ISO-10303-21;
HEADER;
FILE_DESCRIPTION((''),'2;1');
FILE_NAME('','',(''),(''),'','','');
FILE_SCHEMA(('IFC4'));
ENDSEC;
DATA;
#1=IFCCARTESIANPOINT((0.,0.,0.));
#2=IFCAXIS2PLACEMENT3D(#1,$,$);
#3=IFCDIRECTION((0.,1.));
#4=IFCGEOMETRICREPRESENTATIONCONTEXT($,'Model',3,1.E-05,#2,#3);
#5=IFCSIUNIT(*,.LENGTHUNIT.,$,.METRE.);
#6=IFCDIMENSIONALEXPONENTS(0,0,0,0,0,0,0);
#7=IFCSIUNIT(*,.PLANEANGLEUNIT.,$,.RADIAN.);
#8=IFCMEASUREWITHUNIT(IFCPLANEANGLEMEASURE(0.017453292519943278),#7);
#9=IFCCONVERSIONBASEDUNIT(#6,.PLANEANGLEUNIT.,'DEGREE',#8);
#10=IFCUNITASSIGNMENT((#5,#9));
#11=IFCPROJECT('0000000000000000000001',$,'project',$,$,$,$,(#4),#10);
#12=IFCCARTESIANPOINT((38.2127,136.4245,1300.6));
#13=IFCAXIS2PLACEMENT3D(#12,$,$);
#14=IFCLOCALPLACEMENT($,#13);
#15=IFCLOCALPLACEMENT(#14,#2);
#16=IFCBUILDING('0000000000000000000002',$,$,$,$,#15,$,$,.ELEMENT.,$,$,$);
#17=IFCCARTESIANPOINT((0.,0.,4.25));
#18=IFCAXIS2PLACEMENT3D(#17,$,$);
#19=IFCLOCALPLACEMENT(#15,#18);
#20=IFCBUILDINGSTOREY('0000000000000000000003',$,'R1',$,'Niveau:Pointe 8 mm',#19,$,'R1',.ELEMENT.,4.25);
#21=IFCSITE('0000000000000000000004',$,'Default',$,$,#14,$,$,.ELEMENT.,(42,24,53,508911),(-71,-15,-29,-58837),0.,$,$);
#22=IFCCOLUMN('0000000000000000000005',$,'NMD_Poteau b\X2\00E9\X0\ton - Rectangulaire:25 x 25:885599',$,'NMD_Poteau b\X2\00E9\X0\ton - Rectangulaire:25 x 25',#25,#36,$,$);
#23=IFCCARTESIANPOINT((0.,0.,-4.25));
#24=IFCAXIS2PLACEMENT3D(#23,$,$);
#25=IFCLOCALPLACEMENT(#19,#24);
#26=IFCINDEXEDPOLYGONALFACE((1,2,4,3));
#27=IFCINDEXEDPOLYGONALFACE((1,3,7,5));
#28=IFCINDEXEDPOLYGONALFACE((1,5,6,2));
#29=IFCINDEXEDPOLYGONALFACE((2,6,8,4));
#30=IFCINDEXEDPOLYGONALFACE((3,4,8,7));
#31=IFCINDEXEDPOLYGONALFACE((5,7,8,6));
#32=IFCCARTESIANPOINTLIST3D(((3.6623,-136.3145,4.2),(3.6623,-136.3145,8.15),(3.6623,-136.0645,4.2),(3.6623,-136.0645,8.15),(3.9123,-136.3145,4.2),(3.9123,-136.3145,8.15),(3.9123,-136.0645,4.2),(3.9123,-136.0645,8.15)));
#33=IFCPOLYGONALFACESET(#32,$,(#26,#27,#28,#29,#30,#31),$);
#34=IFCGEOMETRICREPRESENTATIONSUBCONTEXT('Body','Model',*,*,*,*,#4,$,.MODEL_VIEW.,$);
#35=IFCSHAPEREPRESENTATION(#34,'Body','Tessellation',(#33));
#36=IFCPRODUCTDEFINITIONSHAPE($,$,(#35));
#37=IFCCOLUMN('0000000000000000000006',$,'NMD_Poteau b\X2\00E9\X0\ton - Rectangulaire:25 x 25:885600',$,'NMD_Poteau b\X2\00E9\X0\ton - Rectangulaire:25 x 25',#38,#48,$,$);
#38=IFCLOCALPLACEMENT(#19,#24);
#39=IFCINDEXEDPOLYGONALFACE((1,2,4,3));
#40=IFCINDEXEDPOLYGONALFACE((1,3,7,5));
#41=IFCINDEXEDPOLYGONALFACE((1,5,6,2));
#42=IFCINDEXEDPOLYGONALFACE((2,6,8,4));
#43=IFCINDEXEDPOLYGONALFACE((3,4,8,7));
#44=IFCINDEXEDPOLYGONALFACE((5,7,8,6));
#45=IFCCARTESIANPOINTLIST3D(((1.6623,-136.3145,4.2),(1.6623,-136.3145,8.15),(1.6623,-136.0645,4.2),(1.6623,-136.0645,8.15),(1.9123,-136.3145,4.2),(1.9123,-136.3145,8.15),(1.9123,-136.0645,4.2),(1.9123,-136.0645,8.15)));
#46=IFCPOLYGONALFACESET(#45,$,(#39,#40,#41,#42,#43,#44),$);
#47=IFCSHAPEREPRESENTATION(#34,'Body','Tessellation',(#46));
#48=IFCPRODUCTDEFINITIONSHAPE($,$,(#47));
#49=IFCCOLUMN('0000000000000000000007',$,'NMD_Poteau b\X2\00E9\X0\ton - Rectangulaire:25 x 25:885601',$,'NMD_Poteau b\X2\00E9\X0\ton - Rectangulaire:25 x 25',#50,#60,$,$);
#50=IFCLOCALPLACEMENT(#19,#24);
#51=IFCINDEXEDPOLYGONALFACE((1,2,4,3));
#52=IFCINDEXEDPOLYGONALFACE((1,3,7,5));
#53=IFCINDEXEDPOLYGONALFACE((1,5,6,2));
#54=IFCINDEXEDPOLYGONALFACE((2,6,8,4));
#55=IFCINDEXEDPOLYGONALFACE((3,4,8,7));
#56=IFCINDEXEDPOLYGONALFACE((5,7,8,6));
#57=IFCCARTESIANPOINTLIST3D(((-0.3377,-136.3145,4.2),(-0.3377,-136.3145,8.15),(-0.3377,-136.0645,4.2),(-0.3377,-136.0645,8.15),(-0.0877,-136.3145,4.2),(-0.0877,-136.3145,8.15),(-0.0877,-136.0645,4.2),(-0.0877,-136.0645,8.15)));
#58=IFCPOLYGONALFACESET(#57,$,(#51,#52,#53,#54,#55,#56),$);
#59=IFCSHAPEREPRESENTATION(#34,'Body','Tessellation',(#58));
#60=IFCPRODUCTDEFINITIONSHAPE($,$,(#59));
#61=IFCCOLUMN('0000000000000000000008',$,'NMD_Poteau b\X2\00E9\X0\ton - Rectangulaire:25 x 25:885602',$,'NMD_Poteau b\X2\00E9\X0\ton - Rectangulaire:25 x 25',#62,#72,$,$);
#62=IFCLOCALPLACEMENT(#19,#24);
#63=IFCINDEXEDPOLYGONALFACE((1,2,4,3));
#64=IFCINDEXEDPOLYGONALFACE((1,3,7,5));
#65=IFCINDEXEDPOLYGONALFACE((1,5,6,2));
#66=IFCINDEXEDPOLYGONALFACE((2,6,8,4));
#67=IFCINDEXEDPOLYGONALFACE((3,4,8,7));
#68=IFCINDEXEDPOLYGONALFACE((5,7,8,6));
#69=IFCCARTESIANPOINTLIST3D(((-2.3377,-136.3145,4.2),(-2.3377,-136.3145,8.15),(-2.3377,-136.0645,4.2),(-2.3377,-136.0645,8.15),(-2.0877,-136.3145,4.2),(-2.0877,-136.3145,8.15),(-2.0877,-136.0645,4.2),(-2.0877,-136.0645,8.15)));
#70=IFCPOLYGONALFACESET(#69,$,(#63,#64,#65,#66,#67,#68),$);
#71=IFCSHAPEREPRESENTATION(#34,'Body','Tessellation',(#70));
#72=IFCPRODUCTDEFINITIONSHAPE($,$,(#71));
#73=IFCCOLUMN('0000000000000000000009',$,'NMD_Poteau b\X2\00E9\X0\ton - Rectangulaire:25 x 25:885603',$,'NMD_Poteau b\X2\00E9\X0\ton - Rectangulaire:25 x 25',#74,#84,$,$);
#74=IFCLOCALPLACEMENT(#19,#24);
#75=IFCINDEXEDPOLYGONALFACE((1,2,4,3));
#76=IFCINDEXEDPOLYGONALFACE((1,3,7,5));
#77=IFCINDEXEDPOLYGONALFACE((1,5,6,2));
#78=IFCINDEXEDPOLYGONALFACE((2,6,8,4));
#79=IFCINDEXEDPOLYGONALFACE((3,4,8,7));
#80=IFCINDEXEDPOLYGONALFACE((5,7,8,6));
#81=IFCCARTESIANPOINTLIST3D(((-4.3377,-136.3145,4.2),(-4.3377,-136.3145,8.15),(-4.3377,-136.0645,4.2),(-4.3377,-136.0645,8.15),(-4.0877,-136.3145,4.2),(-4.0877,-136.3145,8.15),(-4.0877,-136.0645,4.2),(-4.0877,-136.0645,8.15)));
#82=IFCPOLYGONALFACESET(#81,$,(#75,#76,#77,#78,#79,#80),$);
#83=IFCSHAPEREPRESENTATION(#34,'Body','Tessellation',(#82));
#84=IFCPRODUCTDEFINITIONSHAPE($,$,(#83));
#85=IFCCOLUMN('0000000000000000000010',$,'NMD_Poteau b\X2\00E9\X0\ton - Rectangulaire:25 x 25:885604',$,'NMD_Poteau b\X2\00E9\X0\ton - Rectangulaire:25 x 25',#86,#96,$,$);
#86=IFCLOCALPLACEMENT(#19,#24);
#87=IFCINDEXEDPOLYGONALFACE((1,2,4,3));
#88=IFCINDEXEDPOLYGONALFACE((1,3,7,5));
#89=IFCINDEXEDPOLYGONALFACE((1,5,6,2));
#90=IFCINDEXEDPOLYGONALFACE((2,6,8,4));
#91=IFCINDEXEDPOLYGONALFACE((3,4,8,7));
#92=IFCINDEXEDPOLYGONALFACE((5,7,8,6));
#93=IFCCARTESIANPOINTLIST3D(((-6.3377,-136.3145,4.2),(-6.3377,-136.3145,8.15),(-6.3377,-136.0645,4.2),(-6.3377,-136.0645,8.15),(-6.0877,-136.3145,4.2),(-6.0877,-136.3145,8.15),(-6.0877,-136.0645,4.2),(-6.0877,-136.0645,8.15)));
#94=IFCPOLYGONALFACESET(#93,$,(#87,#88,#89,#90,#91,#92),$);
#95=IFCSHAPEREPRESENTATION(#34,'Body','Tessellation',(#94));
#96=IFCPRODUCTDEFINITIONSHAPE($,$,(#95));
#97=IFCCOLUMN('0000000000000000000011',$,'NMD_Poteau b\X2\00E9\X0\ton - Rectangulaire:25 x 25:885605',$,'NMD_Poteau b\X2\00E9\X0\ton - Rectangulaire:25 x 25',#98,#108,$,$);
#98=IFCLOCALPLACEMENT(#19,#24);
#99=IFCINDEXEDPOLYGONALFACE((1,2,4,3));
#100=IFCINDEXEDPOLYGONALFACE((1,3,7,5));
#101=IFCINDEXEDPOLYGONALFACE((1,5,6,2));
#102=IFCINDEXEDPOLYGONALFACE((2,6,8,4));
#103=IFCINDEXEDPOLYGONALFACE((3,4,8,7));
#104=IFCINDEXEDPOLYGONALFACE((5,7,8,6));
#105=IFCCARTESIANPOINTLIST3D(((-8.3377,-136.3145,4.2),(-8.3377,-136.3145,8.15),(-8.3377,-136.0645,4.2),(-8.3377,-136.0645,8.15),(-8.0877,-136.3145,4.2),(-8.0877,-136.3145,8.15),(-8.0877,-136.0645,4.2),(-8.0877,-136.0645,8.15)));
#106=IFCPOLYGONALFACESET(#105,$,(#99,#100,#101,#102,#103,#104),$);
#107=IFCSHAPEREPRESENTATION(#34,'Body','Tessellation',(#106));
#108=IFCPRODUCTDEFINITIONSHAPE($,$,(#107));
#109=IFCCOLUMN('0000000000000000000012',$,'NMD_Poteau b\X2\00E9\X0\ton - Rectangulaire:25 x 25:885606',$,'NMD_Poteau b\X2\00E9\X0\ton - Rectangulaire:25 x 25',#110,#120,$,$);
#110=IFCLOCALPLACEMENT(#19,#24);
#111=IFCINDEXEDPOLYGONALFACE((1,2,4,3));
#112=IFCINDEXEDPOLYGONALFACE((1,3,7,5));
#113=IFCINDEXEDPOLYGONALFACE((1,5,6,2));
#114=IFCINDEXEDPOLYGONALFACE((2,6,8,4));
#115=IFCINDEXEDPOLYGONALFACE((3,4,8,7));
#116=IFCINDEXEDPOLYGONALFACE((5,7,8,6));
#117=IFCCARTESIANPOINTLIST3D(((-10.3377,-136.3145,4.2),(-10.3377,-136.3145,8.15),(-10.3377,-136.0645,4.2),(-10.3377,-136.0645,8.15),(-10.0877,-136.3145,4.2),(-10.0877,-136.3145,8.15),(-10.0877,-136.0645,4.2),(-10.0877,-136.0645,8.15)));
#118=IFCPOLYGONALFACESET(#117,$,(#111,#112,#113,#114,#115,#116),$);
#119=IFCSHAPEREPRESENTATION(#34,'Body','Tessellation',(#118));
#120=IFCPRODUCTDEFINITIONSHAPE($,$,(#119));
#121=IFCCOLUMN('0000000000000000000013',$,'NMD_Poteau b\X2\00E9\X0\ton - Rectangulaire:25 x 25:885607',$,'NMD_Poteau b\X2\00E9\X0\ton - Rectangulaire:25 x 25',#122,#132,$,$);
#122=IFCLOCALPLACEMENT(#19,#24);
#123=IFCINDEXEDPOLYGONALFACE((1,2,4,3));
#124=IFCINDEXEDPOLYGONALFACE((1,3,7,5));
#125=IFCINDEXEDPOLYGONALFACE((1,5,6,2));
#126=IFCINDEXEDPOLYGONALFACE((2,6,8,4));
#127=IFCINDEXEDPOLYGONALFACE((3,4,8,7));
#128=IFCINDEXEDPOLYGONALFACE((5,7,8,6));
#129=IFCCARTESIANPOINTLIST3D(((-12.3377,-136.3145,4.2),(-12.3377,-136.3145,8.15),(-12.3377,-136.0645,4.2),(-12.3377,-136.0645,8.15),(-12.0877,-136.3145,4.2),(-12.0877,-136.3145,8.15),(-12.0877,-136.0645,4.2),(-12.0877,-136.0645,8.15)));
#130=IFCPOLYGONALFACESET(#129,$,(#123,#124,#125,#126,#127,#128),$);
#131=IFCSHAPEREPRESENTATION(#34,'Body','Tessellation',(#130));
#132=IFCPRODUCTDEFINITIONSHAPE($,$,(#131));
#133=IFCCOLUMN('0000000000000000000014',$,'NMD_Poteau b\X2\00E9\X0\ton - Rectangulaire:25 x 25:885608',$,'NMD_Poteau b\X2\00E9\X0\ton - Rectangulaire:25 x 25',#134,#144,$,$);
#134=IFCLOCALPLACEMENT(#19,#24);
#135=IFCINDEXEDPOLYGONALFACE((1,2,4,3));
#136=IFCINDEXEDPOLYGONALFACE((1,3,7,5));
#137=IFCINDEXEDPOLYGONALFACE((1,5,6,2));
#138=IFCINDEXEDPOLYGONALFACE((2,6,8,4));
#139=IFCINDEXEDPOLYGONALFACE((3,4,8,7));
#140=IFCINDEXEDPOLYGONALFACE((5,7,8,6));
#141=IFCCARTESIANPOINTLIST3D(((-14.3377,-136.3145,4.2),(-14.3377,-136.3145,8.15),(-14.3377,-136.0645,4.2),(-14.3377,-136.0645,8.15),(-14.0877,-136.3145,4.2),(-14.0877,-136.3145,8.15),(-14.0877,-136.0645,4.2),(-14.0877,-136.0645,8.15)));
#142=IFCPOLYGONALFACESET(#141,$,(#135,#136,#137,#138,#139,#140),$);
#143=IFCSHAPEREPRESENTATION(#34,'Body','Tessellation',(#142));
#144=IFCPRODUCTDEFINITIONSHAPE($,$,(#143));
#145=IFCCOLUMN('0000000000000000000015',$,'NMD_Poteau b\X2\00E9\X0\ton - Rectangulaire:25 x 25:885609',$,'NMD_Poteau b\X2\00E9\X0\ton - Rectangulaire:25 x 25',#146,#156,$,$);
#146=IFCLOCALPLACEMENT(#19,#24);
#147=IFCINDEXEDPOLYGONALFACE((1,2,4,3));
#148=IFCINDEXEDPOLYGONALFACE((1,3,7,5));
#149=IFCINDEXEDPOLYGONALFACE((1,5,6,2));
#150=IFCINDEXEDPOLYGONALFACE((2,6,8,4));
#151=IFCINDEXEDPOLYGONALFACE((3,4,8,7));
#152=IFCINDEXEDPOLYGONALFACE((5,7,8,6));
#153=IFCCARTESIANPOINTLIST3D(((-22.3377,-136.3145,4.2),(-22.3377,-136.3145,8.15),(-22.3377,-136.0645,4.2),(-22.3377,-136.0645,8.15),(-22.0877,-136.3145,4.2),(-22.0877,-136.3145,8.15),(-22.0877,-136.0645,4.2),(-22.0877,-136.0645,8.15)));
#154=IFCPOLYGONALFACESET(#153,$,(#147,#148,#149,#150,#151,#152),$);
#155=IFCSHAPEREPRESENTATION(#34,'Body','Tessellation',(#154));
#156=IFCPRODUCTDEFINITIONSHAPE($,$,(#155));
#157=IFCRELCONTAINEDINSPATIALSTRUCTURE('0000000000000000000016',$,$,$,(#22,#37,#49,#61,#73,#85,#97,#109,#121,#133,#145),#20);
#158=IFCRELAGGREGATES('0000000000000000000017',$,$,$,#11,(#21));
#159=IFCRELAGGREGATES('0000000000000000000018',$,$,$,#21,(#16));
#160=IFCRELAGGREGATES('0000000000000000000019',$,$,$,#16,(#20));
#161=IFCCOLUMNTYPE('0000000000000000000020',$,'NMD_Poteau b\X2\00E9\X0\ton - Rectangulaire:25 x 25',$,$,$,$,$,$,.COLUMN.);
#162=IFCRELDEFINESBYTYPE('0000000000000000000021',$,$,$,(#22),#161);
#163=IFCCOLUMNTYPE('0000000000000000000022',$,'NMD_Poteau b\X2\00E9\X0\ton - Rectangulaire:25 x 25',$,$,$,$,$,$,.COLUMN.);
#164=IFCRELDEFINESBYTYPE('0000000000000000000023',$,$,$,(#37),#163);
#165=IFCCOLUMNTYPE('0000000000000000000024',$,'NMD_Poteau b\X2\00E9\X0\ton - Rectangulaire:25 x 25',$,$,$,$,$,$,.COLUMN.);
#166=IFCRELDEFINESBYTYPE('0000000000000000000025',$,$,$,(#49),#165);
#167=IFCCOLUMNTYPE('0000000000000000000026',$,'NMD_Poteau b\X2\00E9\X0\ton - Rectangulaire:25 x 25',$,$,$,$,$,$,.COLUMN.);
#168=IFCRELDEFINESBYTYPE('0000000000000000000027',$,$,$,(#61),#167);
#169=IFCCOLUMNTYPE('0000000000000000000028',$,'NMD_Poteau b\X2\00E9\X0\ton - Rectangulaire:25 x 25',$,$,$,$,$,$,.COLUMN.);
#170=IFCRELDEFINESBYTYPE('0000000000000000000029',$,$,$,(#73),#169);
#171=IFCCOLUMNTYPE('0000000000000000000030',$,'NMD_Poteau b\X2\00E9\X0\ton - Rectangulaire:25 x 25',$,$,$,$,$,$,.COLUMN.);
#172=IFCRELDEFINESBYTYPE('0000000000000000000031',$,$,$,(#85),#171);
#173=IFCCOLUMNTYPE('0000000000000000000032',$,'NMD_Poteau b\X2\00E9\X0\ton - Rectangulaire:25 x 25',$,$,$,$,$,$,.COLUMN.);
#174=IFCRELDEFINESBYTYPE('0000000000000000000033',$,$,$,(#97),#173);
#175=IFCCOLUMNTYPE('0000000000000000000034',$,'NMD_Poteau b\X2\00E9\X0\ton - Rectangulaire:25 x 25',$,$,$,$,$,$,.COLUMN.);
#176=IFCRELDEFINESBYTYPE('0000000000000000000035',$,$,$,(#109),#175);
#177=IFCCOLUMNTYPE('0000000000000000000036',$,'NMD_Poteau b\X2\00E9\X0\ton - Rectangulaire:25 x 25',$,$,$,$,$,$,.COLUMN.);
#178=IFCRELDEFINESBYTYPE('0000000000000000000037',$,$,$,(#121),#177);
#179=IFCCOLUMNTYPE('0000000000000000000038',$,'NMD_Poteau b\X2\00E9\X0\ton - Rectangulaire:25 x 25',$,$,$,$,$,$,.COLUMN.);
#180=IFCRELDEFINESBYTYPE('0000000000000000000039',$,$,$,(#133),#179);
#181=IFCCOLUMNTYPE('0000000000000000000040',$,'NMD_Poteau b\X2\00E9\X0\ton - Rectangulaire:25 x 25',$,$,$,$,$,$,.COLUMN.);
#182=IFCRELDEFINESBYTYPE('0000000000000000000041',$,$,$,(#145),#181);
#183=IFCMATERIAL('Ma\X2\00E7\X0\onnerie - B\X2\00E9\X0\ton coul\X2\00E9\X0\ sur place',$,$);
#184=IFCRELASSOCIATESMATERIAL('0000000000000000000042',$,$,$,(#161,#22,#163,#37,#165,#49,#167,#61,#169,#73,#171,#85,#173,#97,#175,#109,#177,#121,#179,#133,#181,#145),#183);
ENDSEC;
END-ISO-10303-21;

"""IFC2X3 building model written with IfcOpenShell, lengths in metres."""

from ifc_helpers import new_model, entity, si_unit, converted_unit, direction, frame, frame_2d, origin, place, context, subcontext, project, spatial, rectangle, extrude, source, transform, mapped, material, type_object, type_shapes, element, save


model = new_model("IFC2X3")

# Units and contexts
model_context = context("Model", 3, precision=1e-05, world=origin(), true_north=direction((0.0, 1.0)))
body_context = subcontext(model_context, "Body", "Model", "MODEL_VIEW")
ifc_project = project(units=[si_unit("LENGTHUNIT", "METRE"), converted_unit("PLANEANGLEUNIT", "DEGREE", entity("IfcPlaneAngleMeasure", 0.017453292519943278), si_unit("PLANEANGLEUNIT", "RADIAN"), dimensions=[0, 0, 0, 0, 0, 0, 0])], contexts=[model_context])

# Site, building, storey
site_placement = place(None, frame((38.2127, 136.4245, 1300.6)))
site = spatial("IfcSite", under=ifc_project, at=site_placement, Name="Default", CompositionType="ELEMENT", RefLatitude=(42, 24, 53, 508911), RefLongitude=(-71, -15, -29, -58837), RefElevation=0.0)
building_placement = place(site_placement, origin())
building = spatial("IfcBuilding", under=site, at=building_placement, CompositionType="ELEMENT")
storey_placement = place(building_placement, frame((0.0, 0.0, 4.25)))
storey = spatial("IfcBuildingStorey", under=building, at=storey_placement, Name="R1", ObjectType="Niveau:Pointe 8 mm", LongName="R1", CompositionType="ELEMENT", Elevation=4.25)

# Columns
ifc_material = material(Name="Maçonnerie - Béton coulé sur place")
column_type_1 = type_object("IfcColumnType", Name="NMD_Poteau béton - Rectangulaire:25 x 25", PredefinedType="COLUMN", material=ifc_material)
shared_shape_1 = source(origin(), body_context, "Body", "SweptSolid", [
    extrude(rectangle(XDim=0.25, YDim=0.25, at=frame_2d((0.0, 0.0), x_axis=(1.0, 0.0))), frame((3.7873, -136.1895, 4.2), z_axis=(0.0, 0.0, 1.0), x_axis=(-1.0, 0.0, 0.0)), (0.0, 0.0, 1.0), 3.95),
])
type_shapes(column_type_1, [shared_shape_1])
column_1_placement = place(storey_placement, frame((0.0, 0.0, -4.25)))
element("IfcColumn", 1, at=column_1_placement, inside=storey, type_object=column_type_1, material=ifc_material, Name="NMD_Poteau béton - Rectangulaire:25 x 25:885599", ObjectType="NMD_Poteau béton - Rectangulaire:25 x 25", context=body_context, shape_type="MappedRepresentation", body=[
    mapped(shared_shape_1, transform((0.0, 0.0, 0.0), scale=1.0)),
])
column_type_2 = type_object("IfcColumnType", Name="NMD_Poteau béton - Rectangulaire:25 x 25", PredefinedType="COLUMN", material=ifc_material)
shared_shape_2 = source(origin(), body_context, "Body", "SweptSolid", [
    extrude(rectangle(XDim=0.25, YDim=0.25, at=frame_2d((0.0, 0.0), x_axis=(1.0, 0.0))), frame((1.7873, -136.1895, 4.2), z_axis=(0.0, 0.0, 1.0), x_axis=(-1.0, 0.0, 0.0)), (0.0, 0.0, 1.0), 3.95),
])
type_shapes(column_type_2, [shared_shape_2])
column_2_placement = place(storey_placement, frame((0.0, 0.0, -4.25)))
element("IfcColumn", 2, at=column_2_placement, inside=storey, type_object=column_type_2, material=ifc_material, Name="NMD_Poteau béton - Rectangulaire:25 x 25:885600", ObjectType="NMD_Poteau béton - Rectangulaire:25 x 25", context=body_context, shape_type="MappedRepresentation", body=[
    mapped(shared_shape_2, transform((0.0, 0.0, 0.0), scale=1.0)),
])
column_type_3 = type_object("IfcColumnType", Name="NMD_Poteau béton - Rectangulaire:25 x 25", PredefinedType="COLUMN", material=ifc_material)
shared_shape_3 = source(origin(), body_context, "Body", "SweptSolid", [
    extrude(rectangle(XDim=0.25, YDim=0.25, at=frame_2d((0.0, 0.0), x_axis=(1.0, 0.0))), frame((-0.2127, -136.1895, 4.2), z_axis=(0.0, 0.0, 1.0), x_axis=(-1.0, 0.0, 0.0)), (0.0, 0.0, 1.0), 3.95),
])
type_shapes(column_type_3, [shared_shape_3])
column_3_placement = place(storey_placement, frame((0.0, 0.0, -4.25)))
element("IfcColumn", 3, at=column_3_placement, inside=storey, type_object=column_type_3, material=ifc_material, Name="NMD_Poteau béton - Rectangulaire:25 x 25:885601", ObjectType="NMD_Poteau béton - Rectangulaire:25 x 25", context=body_context, shape_type="MappedRepresentation", body=[
    mapped(shared_shape_3, transform((0.0, 0.0, 0.0), scale=1.0)),
])
column_type_4 = type_object("IfcColumnType", Name="NMD_Poteau béton - Rectangulaire:25 x 25", PredefinedType="COLUMN", material=ifc_material)
shared_shape_4 = source(origin(), body_context, "Body", "SweptSolid", [
    extrude(rectangle(XDim=0.25, YDim=0.25, at=frame_2d((0.0, 0.0), x_axis=(1.0, 0.0))), frame((-2.2127, -136.1895, 4.2), z_axis=(0.0, 0.0, 1.0), x_axis=(-1.0, 0.0, 0.0)), (0.0, 0.0, 1.0), 3.95),
])
type_shapes(column_type_4, [shared_shape_4])
column_4_placement = place(storey_placement, frame((0.0, 0.0, -4.25)))
element("IfcColumn", 4, at=column_4_placement, inside=storey, type_object=column_type_4, material=ifc_material, Name="NMD_Poteau béton - Rectangulaire:25 x 25:885602", ObjectType="NMD_Poteau béton - Rectangulaire:25 x 25", context=body_context, shape_type="MappedRepresentation", body=[
    mapped(shared_shape_4, transform((0.0, 0.0, 0.0), scale=1.0)),
])
column_type_5 = type_object("IfcColumnType", Name="NMD_Poteau béton - Rectangulaire:25 x 25", PredefinedType="COLUMN", material=ifc_material)
shared_shape_5 = source(origin(), body_context, "Body", "SweptSolid", [
    extrude(rectangle(XDim=0.25, YDim=0.25, at=frame_2d((0.0, 0.0), x_axis=(1.0, 0.0))), frame((-4.2127, -136.1895, 4.2), z_axis=(0.0, 0.0, 1.0), x_axis=(-1.0, 0.0, 0.0)), (0.0, 0.0, 1.0), 3.95),
])
type_shapes(column_type_5, [shared_shape_5])
column_5_placement = place(storey_placement, frame((0.0, 0.0, -4.25)))
element("IfcColumn", 5, at=column_5_placement, inside=storey, type_object=column_type_5, material=ifc_material, Name="NMD_Poteau béton - Rectangulaire:25 x 25:885603", ObjectType="NMD_Poteau béton - Rectangulaire:25 x 25", context=body_context, shape_type="MappedRepresentation", body=[
    mapped(shared_shape_5, transform((0.0, 0.0, 0.0), scale=1.0)),
])
column_type_6 = type_object("IfcColumnType", Name="NMD_Poteau béton - Rectangulaire:25 x 25", PredefinedType="COLUMN", material=ifc_material)
shared_shape_6 = source(origin(), body_context, "Body", "SweptSolid", [
    extrude(rectangle(XDim=0.25, YDim=0.25, at=frame_2d((0.0, 0.0), x_axis=(1.0, 0.0))), frame((-6.2127, -136.1895, 4.2), z_axis=(0.0, 0.0, 1.0), x_axis=(-1.0, 0.0, 0.0)), (0.0, 0.0, 1.0), 3.95),
])
type_shapes(column_type_6, [shared_shape_6])
column_6_placement = place(storey_placement, frame((0.0, 0.0, -4.25)))
element("IfcColumn", 6, at=column_6_placement, inside=storey, type_object=column_type_6, material=ifc_material, Name="NMD_Poteau béton - Rectangulaire:25 x 25:885604", ObjectType="NMD_Poteau béton - Rectangulaire:25 x 25", context=body_context, shape_type="MappedRepresentation", body=[
    mapped(shared_shape_6, transform((0.0, 0.0, 0.0), scale=1.0)),
])
column_type_7 = type_object("IfcColumnType", Name="NMD_Poteau béton - Rectangulaire:25 x 25", PredefinedType="COLUMN", material=ifc_material)
shared_shape_7 = source(origin(), body_context, "Body", "SweptSolid", [
    extrude(rectangle(XDim=0.25, YDim=0.25, at=frame_2d((0.0, 0.0), x_axis=(1.0, 0.0))), frame((-8.2127, -136.1895, 4.2), z_axis=(0.0, 0.0, 1.0), x_axis=(-1.0, 0.0, 0.0)), (0.0, 0.0, 1.0), 3.95),
])
type_shapes(column_type_7, [shared_shape_7])
column_7_placement = place(storey_placement, frame((0.0, 0.0, -4.25)))
element("IfcColumn", 7, at=column_7_placement, inside=storey, type_object=column_type_7, material=ifc_material, Name="NMD_Poteau béton - Rectangulaire:25 x 25:885605", ObjectType="NMD_Poteau béton - Rectangulaire:25 x 25", context=body_context, shape_type="MappedRepresentation", body=[
    mapped(shared_shape_7, transform((0.0, 0.0, 0.0), scale=1.0)),
])
column_type_8 = type_object("IfcColumnType", Name="NMD_Poteau béton - Rectangulaire:25 x 25", PredefinedType="COLUMN", material=ifc_material)
shared_shape_8 = source(origin(), body_context, "Body", "SweptSolid", [
    extrude(rectangle(XDim=0.25, YDim=0.25, at=frame_2d((0.0, 0.0), x_axis=(1.0, 0.0))), frame((-10.2127, -136.1895, 4.2), z_axis=(0.0, 0.0, 1.0), x_axis=(-1.0, 0.0, 0.0)), (0.0, 0.0, 1.0), 3.95),
])
type_shapes(column_type_8, [shared_shape_8])
column_8_placement = place(storey_placement, frame((0.0, 0.0, -4.25)))
element("IfcColumn", 8, at=column_8_placement, inside=storey, type_object=column_type_8, material=ifc_material, Name="NMD_Poteau béton - Rectangulaire:25 x 25:885606", ObjectType="NMD_Poteau béton - Rectangulaire:25 x 25", context=body_context, shape_type="MappedRepresentation", body=[
    mapped(shared_shape_8, transform((0.0, 0.0, 0.0), scale=1.0)),
])
column_type_9 = type_object("IfcColumnType", Name="NMD_Poteau béton - Rectangulaire:25 x 25", PredefinedType="COLUMN", material=ifc_material)
shared_shape_9 = source(origin(), body_context, "Body", "SweptSolid", [
    extrude(rectangle(XDim=0.25, YDim=0.25, at=frame_2d((0.0, 0.0), x_axis=(1.0, 0.0))), frame((-12.2127, -136.1895, 4.2), z_axis=(0.0, 0.0, 1.0), x_axis=(-1.0, 0.0, 0.0)), (0.0, 0.0, 1.0), 3.95),
])
type_shapes(column_type_9, [shared_shape_9])
column_9_placement = place(storey_placement, frame((0.0, 0.0, -4.25)))
element("IfcColumn", 9, at=column_9_placement, inside=storey, type_object=column_type_9, material=ifc_material, Name="NMD_Poteau béton - Rectangulaire:25 x 25:885607", ObjectType="NMD_Poteau béton - Rectangulaire:25 x 25", context=body_context, shape_type="MappedRepresentation", body=[
    mapped(shared_shape_9, transform((0.0, 0.0, 0.0), scale=1.0)),
])
column_type_10 = type_object("IfcColumnType", Name="NMD_Poteau béton - Rectangulaire:25 x 25", PredefinedType="COLUMN", material=ifc_material)
shared_shape_10 = source(origin(), body_context, "Body", "SweptSolid", [
    extrude(rectangle(XDim=0.25, YDim=0.25, at=frame_2d((0.0, 0.0), x_axis=(1.0, 0.0))), frame((-14.2127, -136.1895, 4.2), z_axis=(0.0, 0.0, 1.0), x_axis=(-1.0, 0.0, 0.0)), (0.0, 0.0, 1.0), 3.95),
])
type_shapes(column_type_10, [shared_shape_10])
column_10_placement = place(storey_placement, frame((0.0, 0.0, -4.25)))
element("IfcColumn", 10, at=column_10_placement, inside=storey, type_object=column_type_10, material=ifc_material, Name="NMD_Poteau béton - Rectangulaire:25 x 25:885608", ObjectType="NMD_Poteau béton - Rectangulaire:25 x 25", context=body_context, shape_type="MappedRepresentation", body=[
    mapped(shared_shape_10, transform((0.0, 0.0, 0.0), scale=1.0)),
])
column_type_11 = type_object("IfcColumnType", Name="NMD_Poteau béton - Rectangulaire:25 x 25", PredefinedType="COLUMN", material=ifc_material)
shared_shape_11 = source(origin(), body_context, "Body", "SweptSolid", [
    extrude(rectangle(XDim=0.25, YDim=0.25, at=frame_2d((0.0, 0.0), x_axis=(1.0, 0.0))), frame((-22.2127, -136.1895, 4.2), z_axis=(0.0, 0.0, 1.0), x_axis=(-1.0, 0.0, 0.0)), (0.0, 0.0, 1.0), 3.95),
])
type_shapes(column_type_11, [shared_shape_11])
column_11_placement = place(storey_placement, frame((0.0, 0.0, -4.25)))
element("IfcColumn", 11, at=column_11_placement, inside=storey, type_object=column_type_11, material=ifc_material, Name="NMD_Poteau béton - Rectangulaire:25 x 25:885609", ObjectType="NMD_Poteau béton - Rectangulaire:25 x 25", context=body_context, shape_type="MappedRepresentation", body=[
    mapped(shared_shape_11, transform((0.0, 0.0, 0.0), scale=1.0)),
])

save(model, "model.ifc")
